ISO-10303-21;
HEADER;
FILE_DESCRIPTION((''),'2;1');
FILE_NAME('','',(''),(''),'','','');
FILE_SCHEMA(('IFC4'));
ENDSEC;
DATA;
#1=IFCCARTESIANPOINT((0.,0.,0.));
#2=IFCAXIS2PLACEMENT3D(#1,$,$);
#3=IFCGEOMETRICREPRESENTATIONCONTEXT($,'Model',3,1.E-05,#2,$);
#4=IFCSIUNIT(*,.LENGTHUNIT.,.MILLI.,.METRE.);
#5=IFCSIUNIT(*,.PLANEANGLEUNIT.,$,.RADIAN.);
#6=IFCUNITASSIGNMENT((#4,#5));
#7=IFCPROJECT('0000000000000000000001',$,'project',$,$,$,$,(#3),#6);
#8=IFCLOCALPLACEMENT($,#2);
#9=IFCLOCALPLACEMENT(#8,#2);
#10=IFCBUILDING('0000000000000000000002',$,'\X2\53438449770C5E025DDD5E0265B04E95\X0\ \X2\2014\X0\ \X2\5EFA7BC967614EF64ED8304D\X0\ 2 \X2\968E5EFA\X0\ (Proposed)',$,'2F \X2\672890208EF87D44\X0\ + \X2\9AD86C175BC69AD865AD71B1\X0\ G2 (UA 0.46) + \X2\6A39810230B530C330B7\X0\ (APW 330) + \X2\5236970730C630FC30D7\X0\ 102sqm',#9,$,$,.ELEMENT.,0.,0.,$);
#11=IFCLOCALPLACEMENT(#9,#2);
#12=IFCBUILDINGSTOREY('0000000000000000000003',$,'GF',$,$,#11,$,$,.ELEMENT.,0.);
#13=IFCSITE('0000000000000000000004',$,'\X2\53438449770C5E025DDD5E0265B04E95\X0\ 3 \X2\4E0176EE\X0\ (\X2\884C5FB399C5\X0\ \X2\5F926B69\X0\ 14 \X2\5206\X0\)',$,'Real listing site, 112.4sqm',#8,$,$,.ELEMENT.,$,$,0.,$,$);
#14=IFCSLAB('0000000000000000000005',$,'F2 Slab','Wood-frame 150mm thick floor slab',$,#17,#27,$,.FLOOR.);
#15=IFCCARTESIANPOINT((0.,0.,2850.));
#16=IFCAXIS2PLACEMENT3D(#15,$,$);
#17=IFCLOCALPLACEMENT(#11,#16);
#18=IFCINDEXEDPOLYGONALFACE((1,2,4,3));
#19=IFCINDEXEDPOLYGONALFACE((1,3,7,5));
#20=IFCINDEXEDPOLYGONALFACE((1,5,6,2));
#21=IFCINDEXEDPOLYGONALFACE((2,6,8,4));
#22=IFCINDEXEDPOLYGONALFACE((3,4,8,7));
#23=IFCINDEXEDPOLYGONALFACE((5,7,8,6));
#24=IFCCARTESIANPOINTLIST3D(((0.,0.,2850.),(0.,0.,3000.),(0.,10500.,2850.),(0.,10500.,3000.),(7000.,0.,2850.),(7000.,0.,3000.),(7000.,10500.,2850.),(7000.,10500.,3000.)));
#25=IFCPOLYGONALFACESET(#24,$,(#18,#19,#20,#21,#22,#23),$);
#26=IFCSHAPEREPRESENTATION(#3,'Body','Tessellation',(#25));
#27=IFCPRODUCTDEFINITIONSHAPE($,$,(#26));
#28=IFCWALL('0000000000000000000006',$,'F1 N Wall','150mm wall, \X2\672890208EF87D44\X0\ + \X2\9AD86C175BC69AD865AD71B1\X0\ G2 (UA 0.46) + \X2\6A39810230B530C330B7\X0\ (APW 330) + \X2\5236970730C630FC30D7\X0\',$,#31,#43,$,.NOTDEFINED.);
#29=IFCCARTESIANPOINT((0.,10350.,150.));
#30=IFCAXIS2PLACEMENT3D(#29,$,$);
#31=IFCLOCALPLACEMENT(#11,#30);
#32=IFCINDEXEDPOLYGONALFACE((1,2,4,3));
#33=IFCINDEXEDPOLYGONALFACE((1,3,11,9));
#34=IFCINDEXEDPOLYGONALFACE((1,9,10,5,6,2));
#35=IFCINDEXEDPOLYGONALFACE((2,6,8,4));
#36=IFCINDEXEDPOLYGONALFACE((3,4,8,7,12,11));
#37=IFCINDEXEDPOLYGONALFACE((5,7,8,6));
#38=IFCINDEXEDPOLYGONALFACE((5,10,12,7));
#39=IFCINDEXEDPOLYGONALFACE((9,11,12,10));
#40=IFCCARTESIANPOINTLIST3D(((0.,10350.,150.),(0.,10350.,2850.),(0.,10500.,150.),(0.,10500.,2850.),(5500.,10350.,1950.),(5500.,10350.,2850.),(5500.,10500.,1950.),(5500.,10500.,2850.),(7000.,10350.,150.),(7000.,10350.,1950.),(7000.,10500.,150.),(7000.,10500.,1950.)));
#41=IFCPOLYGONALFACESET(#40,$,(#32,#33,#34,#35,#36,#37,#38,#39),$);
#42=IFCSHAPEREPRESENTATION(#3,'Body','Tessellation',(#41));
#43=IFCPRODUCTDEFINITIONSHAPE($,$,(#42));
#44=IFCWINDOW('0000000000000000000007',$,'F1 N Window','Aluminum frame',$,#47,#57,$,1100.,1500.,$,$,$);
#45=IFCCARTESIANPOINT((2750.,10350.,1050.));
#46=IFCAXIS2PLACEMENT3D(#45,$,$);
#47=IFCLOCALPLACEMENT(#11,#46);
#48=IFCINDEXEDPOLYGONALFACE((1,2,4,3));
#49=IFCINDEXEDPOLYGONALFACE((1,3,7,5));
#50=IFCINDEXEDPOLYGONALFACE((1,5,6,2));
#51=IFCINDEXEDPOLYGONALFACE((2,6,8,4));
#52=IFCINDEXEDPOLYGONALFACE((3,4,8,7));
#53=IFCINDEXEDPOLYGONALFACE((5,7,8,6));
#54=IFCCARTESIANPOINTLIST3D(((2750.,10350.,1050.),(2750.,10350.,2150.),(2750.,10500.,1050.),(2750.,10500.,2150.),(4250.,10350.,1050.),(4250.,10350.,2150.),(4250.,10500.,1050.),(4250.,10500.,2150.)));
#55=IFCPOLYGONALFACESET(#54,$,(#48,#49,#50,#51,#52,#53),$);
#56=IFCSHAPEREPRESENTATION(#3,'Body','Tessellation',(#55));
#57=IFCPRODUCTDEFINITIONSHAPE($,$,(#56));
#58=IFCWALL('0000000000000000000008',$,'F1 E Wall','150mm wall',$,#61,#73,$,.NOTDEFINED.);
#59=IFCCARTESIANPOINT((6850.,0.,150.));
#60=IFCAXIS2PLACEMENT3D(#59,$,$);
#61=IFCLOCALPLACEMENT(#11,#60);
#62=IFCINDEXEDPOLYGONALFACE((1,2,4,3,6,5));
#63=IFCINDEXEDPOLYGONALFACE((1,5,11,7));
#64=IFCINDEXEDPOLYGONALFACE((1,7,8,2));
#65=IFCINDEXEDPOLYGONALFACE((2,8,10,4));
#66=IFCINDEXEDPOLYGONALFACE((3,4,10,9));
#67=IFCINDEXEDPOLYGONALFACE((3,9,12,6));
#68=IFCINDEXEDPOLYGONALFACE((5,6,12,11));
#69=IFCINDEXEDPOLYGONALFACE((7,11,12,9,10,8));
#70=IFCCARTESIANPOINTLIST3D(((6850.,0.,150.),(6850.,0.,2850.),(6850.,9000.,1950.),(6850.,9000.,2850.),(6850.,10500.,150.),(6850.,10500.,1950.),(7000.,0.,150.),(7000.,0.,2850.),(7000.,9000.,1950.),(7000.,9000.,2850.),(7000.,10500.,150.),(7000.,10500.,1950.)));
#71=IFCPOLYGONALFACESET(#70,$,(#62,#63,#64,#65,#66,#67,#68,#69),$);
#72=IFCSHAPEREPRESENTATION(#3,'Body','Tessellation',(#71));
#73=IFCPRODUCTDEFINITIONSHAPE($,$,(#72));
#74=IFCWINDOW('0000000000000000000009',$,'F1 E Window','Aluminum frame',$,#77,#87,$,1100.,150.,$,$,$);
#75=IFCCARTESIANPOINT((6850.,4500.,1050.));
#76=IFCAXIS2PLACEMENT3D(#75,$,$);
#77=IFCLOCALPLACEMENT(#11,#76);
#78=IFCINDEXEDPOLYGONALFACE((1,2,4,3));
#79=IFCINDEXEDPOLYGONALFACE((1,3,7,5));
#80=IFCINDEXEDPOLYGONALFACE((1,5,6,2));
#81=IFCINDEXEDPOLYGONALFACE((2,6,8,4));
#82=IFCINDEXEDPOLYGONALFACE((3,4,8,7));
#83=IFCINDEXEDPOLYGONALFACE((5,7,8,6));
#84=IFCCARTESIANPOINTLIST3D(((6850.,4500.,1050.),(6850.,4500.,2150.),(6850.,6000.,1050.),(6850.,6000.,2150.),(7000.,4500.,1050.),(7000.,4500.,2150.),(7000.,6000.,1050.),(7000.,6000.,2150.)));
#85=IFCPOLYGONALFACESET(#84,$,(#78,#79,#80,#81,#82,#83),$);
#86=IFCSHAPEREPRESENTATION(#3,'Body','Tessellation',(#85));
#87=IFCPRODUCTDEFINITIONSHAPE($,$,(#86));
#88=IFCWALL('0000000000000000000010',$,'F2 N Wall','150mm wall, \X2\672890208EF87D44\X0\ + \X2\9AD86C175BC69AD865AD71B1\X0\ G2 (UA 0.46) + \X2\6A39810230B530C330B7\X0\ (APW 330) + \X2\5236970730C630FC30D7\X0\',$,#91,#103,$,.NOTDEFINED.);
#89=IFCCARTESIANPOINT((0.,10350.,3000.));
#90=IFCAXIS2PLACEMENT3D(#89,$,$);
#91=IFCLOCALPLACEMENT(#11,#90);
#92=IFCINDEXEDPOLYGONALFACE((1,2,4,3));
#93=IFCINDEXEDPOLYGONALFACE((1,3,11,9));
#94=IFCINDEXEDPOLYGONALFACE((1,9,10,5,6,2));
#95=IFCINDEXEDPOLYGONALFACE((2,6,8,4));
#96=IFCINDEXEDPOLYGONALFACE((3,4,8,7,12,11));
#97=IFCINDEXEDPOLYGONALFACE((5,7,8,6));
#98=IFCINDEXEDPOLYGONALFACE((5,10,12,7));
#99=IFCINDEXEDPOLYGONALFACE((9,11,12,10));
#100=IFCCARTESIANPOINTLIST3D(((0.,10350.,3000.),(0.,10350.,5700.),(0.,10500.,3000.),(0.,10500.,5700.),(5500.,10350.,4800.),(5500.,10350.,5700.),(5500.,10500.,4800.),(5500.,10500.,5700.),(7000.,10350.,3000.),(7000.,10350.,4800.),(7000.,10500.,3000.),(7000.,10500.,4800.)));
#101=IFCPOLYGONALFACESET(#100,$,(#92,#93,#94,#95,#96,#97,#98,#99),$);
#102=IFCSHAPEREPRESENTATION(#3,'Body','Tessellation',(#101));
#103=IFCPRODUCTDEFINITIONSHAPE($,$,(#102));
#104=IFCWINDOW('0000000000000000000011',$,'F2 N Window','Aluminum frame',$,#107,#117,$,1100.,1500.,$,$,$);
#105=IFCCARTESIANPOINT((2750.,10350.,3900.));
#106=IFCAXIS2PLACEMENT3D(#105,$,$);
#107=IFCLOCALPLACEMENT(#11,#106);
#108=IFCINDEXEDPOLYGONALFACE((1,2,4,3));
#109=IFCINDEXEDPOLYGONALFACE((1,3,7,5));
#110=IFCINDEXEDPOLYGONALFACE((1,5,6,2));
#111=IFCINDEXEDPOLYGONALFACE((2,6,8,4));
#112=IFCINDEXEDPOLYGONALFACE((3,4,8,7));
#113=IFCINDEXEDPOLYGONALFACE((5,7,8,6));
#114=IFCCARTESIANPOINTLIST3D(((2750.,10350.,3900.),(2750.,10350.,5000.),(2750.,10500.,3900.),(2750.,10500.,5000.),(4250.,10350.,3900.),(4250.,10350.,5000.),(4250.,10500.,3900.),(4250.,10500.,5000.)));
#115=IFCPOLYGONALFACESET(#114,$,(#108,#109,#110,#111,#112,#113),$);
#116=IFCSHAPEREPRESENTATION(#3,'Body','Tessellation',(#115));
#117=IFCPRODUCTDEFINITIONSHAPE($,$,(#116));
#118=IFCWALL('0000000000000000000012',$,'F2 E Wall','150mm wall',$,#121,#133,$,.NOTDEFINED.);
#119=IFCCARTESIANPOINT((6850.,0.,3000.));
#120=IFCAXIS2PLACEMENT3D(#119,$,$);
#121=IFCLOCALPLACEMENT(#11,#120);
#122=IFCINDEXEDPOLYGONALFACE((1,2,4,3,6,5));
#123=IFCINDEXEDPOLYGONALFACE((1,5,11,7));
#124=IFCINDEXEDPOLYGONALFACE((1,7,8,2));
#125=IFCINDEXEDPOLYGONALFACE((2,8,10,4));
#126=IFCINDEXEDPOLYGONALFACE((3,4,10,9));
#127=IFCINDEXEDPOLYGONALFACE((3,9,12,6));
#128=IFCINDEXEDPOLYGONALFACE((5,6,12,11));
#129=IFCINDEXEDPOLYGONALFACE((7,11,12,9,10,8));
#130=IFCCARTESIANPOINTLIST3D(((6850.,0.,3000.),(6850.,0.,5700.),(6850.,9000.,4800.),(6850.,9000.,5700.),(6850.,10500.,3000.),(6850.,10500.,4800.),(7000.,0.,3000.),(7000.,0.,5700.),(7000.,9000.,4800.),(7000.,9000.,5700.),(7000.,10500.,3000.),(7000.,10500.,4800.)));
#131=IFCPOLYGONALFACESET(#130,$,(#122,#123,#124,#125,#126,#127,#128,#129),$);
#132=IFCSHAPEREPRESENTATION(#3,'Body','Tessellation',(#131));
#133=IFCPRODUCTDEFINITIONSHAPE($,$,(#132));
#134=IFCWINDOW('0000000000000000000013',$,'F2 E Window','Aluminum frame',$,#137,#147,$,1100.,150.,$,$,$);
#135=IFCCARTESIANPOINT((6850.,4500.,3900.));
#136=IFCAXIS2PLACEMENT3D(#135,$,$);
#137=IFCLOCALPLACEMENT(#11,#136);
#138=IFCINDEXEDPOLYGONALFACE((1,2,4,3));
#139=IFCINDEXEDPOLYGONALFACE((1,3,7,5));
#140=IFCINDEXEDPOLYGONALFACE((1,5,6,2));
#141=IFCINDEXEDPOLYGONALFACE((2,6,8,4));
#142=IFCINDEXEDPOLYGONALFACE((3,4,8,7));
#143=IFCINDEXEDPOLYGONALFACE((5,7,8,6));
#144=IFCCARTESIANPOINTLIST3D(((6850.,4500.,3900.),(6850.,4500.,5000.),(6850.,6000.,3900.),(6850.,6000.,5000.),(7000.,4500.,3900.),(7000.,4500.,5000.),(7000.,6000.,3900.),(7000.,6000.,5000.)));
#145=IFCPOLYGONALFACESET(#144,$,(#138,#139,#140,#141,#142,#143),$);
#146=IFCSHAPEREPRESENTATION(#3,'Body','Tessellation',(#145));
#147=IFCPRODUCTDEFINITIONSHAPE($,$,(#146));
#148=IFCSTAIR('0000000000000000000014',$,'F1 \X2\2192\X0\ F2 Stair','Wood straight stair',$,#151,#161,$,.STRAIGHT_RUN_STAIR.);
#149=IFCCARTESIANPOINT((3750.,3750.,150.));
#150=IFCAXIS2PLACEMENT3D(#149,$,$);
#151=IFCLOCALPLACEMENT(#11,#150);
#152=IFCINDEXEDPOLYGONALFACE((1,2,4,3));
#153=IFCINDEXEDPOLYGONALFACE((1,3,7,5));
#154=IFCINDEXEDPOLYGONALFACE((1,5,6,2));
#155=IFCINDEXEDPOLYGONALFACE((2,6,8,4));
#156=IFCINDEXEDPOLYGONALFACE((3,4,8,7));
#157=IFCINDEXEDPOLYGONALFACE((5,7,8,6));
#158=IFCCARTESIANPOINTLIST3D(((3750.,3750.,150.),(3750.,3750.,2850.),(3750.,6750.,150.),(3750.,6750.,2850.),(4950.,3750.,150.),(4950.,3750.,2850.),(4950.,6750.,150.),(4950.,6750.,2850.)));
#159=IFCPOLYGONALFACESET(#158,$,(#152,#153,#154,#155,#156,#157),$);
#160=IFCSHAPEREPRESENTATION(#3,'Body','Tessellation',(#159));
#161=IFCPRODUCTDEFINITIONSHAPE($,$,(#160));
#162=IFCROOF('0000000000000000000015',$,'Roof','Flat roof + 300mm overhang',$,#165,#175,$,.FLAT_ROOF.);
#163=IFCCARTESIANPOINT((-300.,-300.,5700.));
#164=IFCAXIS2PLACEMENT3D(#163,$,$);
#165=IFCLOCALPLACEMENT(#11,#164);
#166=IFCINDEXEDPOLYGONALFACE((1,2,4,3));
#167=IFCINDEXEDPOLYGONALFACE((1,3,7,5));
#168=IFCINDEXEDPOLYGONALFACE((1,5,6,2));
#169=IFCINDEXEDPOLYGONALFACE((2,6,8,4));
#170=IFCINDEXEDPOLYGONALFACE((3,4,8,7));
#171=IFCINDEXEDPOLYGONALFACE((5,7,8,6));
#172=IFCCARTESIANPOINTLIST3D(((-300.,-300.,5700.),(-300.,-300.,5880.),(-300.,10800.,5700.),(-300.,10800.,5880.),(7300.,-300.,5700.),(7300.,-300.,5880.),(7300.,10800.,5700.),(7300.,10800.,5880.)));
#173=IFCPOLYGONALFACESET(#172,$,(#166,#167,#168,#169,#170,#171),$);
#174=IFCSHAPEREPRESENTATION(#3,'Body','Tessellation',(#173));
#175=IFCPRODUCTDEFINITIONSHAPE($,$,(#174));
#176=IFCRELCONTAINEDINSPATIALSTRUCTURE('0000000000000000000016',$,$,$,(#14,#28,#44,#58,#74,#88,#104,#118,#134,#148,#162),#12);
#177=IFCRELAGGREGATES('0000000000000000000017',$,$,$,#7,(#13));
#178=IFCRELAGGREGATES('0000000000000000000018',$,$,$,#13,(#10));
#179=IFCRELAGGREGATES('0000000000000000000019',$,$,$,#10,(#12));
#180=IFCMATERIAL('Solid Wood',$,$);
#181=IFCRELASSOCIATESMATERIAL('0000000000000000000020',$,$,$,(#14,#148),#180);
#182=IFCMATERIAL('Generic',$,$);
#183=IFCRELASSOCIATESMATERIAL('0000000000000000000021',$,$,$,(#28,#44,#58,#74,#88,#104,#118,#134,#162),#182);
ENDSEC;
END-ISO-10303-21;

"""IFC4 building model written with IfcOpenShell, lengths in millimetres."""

from ifc_helpers import new_model, si_unit, frame, frame_2d, origin, place, context, project, spatial, rectangle, extrude, material, element, fill, save


model = new_model("IFC4")

# Units and contexts
model_context = context("Model", 3, precision=1e-05, world=origin())
ifc_project = project(units=[si_unit("LENGTHUNIT", "METRE", prefix="MILLI"), si_unit("PLANEANGLEUNIT", "RADIAN")], contexts=[model_context])

# Site, building, storey
site_placement = place(None, origin())
site = spatial("IfcSite", under=ifc_project, at=site_placement, Name="千葉県市川市新井 3 丁目 (行徳駅 徒歩 14 分)", ObjectType="Real listing site, 112.4sqm", CompositionType="ELEMENT", RefElevation=0.0)
building_placement = place(site_placement, origin())
building = spatial("IfcBuilding", under=site, at=building_placement, Name="千葉県市川市新井 — 建築条件付き 2 階建 (Proposed)", ObjectType="2F 木造軸組 + 高気密高断熱 G2 (UA 0.46) + 樹脂サッシ (APW 330) + 制震テープ 102sqm", CompositionType="ELEMENT", ElevationOfRefHeight=0.0, ElevationOfTerrain=0.0)
storey_placement = place(building_placement, origin())
storey = spatial("IfcBuildingStorey", under=building, at=storey_placement, Name="GF", CompositionType="ELEMENT", Elevation=0.0)

# Slab
ifc_material_1 = material(Name="Solid Wood")
slab_1_placement = place(storey_placement, frame((0.0, 0.0, 2850.0)))
element("IfcSlab", 1, at=slab_1_placement, inside=storey, material=ifc_material_1, Name="F2 Slab", Description="Wood-frame 150mm thick floor slab", PredefinedType="FLOOR", context=model_context, shape_type="SweptSolid", body=[
    extrude(rectangle(XDim=7000.0, YDim=10500.0, at=frame_2d((3500.0, 5250.0))), frame((0.0, 0.0, 2850.0)), (0.0, 0.0, 1.0), 150.0),
])

# Wall, opening, window
ifc_material_2 = material(Name="Generic")
wall_1_placement = place(storey_placement, frame((0.0, 10350.0, 150.0)))
wall_1 = element("IfcWall", 2, at=wall_1_placement, inside=storey, material=ifc_material_2, Name="F1 N Wall", Description="150mm wall, 木造軸組 + 高気密高断熱 G2 (UA 0.46) + 樹脂サッシ (APW 330) + 制震テープ", PredefinedType="NOTDEFINED", context=model_context, shape_type="SweptSolid", body=[
    extrude(rectangle(XDim=7000.0, YDim=150.0, at=frame_2d((3500.0, 75.0))), frame((0.0, 10350.0, 150.0)), (0.0, 0.0, 1.0), 2700.0),
])
opening_1_placement = place(storey_placement, frame((2750.0, 10350.0, 1050.0)))
opening_1 = element("IfcOpeningElement", 3, at=opening_1_placement, cuts=wall_1, PredefinedType="NOTDEFINED", context=model_context, shape_type="SweptSolid", body=[
    extrude(rectangle(XDim=1500.0, YDim=150.0, at=frame_2d((750.0, 75.0))), frame((2750.0, 10350.0, 1050.0)), (0.0, 0.0, 1.0), 1100.0),
])
window_1_placement = place(storey_placement, frame((2750.0, 10350.0, 1050.0)))
window_1 = element("IfcWindow", 4, at=window_1_placement, inside=storey, material=ifc_material_2, Name="F1 N Window", Description="Aluminum frame", OverallHeight=1100.0, OverallWidth=1500.0, context=model_context, shape_type="SweptSolid", body=[
    extrude(rectangle(XDim=1500.0, YDim=150.0, at=frame_2d((750.0, 75.0))), frame((2750.0, 10350.0, 1050.0)), (0.0, 0.0, 1.0), 1100.0),
])
fill(opening_1, window_1)

# Walls, openings, windows
wall_2_placement = place(storey_placement, frame((6850.0, 0.0, 150.0)))
wall_2 = element("IfcWall", 5, at=wall_2_placement, inside=storey, material=ifc_material_2, Name="F1 E Wall", Description="150mm wall", PredefinedType="NOTDEFINED", context=model_context, shape_type="SweptSolid", body=[
    extrude(rectangle(XDim=150.0, YDim=10500.0, at=frame_2d((75.0, 5250.0))), frame((6850.0, 0.0, 150.0)), (0.0, 0.0, 1.0), 2700.0),
])
opening_2_placement = place(storey_placement, frame((6850.0, 4500.0, 1050.0)))
opening_2 = element("IfcOpeningElement", 6, at=opening_2_placement, cuts=wall_2, PredefinedType="NOTDEFINED", context=model_context, shape_type="SweptSolid", body=[
    extrude(rectangle(XDim=150.0, YDim=1500.0, at=frame_2d((75.0, 750.0))), frame((6850.0, 4500.0, 1050.0)), (0.0, 0.0, 1.0), 1100.0),
])
window_2_placement = place(storey_placement, frame((6850.0, 4500.0, 1050.0)))
window_2 = element("IfcWindow", 7, at=window_2_placement, inside=storey, material=ifc_material_2, Name="F1 E Window", Description="Aluminum frame", OverallHeight=1100.0, OverallWidth=150.0, context=model_context, shape_type="SweptSolid", body=[
    extrude(rectangle(XDim=150.0, YDim=1500.0, at=frame_2d((75.0, 750.0))), frame((6850.0, 4500.0, 1050.0)), (0.0, 0.0, 1.0), 1100.0),
])
fill(opening_2, window_2)
wall_3_placement = place(storey_placement, frame((0.0, 10350.0, 3000.0)))
wall_3 = element("IfcWall", 8, at=wall_3_placement, inside=storey, material=ifc_material_2, Name="F2 N Wall", Description="150mm wall, 木造軸組 + 高気密高断熱 G2 (UA 0.46) + 樹脂サッシ (APW 330) + 制震テープ", PredefinedType="NOTDEFINED", context=model_context, shape_type="SweptSolid", body=[
    extrude(rectangle(XDim=7000.0, YDim=150.0, at=frame_2d((3500.0, 75.0))), frame((0.0, 10350.0, 3000.0)), (0.0, 0.0, 1.0), 2700.0),
])
opening_3_placement = place(storey_placement, frame((2750.0, 10350.0, 3900.0)))
opening_3 = element("IfcOpeningElement", 9, at=opening_3_placement, cuts=wall_3, PredefinedType="NOTDEFINED", context=model_context, shape_type="SweptSolid", body=[
    extrude(rectangle(XDim=1500.0, YDim=150.0, at=frame_2d((750.0, 75.0))), frame((2750.0, 10350.0, 3900.0)), (0.0, 0.0, 1.0), 1100.0),
])
window_3_placement = place(storey_placement, frame((2750.0, 10350.0, 3900.0)))
window_3 = element("IfcWindow", 10, at=window_3_placement, inside=storey, material=ifc_material_2, Name="F2 N Window", Description="Aluminum frame", OverallHeight=1100.0, OverallWidth=1500.0, context=model_context, shape_type="SweptSolid", body=[
    extrude(rectangle(XDim=1500.0, YDim=150.0, at=frame_2d((750.0, 75.0))), frame((2750.0, 10350.0, 3900.0)), (0.0, 0.0, 1.0), 1100.0),
])
fill(opening_3, window_3)
wall_4_placement = place(storey_placement, frame((6850.0, 0.0, 3000.0)))
wall_4 = element("IfcWall", 11, at=wall_4_placement, inside=storey, material=ifc_material_2, Name="F2 E Wall", Description="150mm wall", PredefinedType="NOTDEFINED", context=model_context, shape_type="SweptSolid", body=[
    extrude(rectangle(XDim=150.0, YDim=10500.0, at=frame_2d((75.0, 5250.0))), frame((6850.0, 0.0, 3000.0)), (0.0, 0.0, 1.0), 2700.0),
])
opening_4_placement = place(storey_placement, frame((6850.0, 4500.0, 3900.0)))
opening_4 = element("IfcOpeningElement", 12, at=opening_4_placement, cuts=wall_4, PredefinedType="NOTDEFINED", context=model_context, shape_type="SweptSolid", body=[
    extrude(rectangle(XDim=150.0, YDim=1500.0, at=frame_2d((75.0, 750.0))), frame((6850.0, 4500.0, 3900.0)), (0.0, 0.0, 1.0), 1100.0),
])
window_4_placement = place(storey_placement, frame((6850.0, 4500.0, 3900.0)))
window_4 = element("IfcWindow", 13, at=window_4_placement, inside=storey, material=ifc_material_2, Name="F2 E Window", Description="Aluminum frame", OverallHeight=1100.0, OverallWidth=150.0, context=model_context, shape_type="SweptSolid", body=[
    extrude(rectangle(XDim=150.0, YDim=1500.0, at=frame_2d((75.0, 750.0))), frame((6850.0, 4500.0, 3900.0)), (0.0, 0.0, 1.0), 1100.0),
])
fill(opening_4, window_4)

# Stair
stair_placement = place(storey_placement, frame((3750.0, 3750.0, 150.0)))
element("IfcStair", 14, at=stair_placement, inside=storey, material=ifc_material_1, Name="F1 → F2 Stair", Description="Wood straight stair", PredefinedType="STRAIGHT_RUN_STAIR", context=model_context, shape_type="SweptSolid", body=[
    extrude(rectangle(XDim=1200.0, YDim=3000.0, at=frame_2d((600.0, 1500.0))), frame((3750.0, 3750.0, 150.0)), (0.0, 0.0, 1.0), 2700.0),
])

# Roof
roof_placement = place(storey_placement, frame((-300.0, -300.0, 5700.0)))
element("IfcRoof", 15, at=roof_placement, inside=storey, material=ifc_material_2, Name="Roof", Description="Flat roof + 300mm overhang", PredefinedType="FLAT_ROOF", context=model_context, shape_type="SweptSolid", body=[
    extrude(rectangle(XDim=7600.0, YDim=11100.0, at=frame_2d((3800.0, 5550.0))), frame((-300.0, -300.0, 5700.0)), (0.0, 0.0, 1.0), 180.0),
])

save(model, "model.ifc")
